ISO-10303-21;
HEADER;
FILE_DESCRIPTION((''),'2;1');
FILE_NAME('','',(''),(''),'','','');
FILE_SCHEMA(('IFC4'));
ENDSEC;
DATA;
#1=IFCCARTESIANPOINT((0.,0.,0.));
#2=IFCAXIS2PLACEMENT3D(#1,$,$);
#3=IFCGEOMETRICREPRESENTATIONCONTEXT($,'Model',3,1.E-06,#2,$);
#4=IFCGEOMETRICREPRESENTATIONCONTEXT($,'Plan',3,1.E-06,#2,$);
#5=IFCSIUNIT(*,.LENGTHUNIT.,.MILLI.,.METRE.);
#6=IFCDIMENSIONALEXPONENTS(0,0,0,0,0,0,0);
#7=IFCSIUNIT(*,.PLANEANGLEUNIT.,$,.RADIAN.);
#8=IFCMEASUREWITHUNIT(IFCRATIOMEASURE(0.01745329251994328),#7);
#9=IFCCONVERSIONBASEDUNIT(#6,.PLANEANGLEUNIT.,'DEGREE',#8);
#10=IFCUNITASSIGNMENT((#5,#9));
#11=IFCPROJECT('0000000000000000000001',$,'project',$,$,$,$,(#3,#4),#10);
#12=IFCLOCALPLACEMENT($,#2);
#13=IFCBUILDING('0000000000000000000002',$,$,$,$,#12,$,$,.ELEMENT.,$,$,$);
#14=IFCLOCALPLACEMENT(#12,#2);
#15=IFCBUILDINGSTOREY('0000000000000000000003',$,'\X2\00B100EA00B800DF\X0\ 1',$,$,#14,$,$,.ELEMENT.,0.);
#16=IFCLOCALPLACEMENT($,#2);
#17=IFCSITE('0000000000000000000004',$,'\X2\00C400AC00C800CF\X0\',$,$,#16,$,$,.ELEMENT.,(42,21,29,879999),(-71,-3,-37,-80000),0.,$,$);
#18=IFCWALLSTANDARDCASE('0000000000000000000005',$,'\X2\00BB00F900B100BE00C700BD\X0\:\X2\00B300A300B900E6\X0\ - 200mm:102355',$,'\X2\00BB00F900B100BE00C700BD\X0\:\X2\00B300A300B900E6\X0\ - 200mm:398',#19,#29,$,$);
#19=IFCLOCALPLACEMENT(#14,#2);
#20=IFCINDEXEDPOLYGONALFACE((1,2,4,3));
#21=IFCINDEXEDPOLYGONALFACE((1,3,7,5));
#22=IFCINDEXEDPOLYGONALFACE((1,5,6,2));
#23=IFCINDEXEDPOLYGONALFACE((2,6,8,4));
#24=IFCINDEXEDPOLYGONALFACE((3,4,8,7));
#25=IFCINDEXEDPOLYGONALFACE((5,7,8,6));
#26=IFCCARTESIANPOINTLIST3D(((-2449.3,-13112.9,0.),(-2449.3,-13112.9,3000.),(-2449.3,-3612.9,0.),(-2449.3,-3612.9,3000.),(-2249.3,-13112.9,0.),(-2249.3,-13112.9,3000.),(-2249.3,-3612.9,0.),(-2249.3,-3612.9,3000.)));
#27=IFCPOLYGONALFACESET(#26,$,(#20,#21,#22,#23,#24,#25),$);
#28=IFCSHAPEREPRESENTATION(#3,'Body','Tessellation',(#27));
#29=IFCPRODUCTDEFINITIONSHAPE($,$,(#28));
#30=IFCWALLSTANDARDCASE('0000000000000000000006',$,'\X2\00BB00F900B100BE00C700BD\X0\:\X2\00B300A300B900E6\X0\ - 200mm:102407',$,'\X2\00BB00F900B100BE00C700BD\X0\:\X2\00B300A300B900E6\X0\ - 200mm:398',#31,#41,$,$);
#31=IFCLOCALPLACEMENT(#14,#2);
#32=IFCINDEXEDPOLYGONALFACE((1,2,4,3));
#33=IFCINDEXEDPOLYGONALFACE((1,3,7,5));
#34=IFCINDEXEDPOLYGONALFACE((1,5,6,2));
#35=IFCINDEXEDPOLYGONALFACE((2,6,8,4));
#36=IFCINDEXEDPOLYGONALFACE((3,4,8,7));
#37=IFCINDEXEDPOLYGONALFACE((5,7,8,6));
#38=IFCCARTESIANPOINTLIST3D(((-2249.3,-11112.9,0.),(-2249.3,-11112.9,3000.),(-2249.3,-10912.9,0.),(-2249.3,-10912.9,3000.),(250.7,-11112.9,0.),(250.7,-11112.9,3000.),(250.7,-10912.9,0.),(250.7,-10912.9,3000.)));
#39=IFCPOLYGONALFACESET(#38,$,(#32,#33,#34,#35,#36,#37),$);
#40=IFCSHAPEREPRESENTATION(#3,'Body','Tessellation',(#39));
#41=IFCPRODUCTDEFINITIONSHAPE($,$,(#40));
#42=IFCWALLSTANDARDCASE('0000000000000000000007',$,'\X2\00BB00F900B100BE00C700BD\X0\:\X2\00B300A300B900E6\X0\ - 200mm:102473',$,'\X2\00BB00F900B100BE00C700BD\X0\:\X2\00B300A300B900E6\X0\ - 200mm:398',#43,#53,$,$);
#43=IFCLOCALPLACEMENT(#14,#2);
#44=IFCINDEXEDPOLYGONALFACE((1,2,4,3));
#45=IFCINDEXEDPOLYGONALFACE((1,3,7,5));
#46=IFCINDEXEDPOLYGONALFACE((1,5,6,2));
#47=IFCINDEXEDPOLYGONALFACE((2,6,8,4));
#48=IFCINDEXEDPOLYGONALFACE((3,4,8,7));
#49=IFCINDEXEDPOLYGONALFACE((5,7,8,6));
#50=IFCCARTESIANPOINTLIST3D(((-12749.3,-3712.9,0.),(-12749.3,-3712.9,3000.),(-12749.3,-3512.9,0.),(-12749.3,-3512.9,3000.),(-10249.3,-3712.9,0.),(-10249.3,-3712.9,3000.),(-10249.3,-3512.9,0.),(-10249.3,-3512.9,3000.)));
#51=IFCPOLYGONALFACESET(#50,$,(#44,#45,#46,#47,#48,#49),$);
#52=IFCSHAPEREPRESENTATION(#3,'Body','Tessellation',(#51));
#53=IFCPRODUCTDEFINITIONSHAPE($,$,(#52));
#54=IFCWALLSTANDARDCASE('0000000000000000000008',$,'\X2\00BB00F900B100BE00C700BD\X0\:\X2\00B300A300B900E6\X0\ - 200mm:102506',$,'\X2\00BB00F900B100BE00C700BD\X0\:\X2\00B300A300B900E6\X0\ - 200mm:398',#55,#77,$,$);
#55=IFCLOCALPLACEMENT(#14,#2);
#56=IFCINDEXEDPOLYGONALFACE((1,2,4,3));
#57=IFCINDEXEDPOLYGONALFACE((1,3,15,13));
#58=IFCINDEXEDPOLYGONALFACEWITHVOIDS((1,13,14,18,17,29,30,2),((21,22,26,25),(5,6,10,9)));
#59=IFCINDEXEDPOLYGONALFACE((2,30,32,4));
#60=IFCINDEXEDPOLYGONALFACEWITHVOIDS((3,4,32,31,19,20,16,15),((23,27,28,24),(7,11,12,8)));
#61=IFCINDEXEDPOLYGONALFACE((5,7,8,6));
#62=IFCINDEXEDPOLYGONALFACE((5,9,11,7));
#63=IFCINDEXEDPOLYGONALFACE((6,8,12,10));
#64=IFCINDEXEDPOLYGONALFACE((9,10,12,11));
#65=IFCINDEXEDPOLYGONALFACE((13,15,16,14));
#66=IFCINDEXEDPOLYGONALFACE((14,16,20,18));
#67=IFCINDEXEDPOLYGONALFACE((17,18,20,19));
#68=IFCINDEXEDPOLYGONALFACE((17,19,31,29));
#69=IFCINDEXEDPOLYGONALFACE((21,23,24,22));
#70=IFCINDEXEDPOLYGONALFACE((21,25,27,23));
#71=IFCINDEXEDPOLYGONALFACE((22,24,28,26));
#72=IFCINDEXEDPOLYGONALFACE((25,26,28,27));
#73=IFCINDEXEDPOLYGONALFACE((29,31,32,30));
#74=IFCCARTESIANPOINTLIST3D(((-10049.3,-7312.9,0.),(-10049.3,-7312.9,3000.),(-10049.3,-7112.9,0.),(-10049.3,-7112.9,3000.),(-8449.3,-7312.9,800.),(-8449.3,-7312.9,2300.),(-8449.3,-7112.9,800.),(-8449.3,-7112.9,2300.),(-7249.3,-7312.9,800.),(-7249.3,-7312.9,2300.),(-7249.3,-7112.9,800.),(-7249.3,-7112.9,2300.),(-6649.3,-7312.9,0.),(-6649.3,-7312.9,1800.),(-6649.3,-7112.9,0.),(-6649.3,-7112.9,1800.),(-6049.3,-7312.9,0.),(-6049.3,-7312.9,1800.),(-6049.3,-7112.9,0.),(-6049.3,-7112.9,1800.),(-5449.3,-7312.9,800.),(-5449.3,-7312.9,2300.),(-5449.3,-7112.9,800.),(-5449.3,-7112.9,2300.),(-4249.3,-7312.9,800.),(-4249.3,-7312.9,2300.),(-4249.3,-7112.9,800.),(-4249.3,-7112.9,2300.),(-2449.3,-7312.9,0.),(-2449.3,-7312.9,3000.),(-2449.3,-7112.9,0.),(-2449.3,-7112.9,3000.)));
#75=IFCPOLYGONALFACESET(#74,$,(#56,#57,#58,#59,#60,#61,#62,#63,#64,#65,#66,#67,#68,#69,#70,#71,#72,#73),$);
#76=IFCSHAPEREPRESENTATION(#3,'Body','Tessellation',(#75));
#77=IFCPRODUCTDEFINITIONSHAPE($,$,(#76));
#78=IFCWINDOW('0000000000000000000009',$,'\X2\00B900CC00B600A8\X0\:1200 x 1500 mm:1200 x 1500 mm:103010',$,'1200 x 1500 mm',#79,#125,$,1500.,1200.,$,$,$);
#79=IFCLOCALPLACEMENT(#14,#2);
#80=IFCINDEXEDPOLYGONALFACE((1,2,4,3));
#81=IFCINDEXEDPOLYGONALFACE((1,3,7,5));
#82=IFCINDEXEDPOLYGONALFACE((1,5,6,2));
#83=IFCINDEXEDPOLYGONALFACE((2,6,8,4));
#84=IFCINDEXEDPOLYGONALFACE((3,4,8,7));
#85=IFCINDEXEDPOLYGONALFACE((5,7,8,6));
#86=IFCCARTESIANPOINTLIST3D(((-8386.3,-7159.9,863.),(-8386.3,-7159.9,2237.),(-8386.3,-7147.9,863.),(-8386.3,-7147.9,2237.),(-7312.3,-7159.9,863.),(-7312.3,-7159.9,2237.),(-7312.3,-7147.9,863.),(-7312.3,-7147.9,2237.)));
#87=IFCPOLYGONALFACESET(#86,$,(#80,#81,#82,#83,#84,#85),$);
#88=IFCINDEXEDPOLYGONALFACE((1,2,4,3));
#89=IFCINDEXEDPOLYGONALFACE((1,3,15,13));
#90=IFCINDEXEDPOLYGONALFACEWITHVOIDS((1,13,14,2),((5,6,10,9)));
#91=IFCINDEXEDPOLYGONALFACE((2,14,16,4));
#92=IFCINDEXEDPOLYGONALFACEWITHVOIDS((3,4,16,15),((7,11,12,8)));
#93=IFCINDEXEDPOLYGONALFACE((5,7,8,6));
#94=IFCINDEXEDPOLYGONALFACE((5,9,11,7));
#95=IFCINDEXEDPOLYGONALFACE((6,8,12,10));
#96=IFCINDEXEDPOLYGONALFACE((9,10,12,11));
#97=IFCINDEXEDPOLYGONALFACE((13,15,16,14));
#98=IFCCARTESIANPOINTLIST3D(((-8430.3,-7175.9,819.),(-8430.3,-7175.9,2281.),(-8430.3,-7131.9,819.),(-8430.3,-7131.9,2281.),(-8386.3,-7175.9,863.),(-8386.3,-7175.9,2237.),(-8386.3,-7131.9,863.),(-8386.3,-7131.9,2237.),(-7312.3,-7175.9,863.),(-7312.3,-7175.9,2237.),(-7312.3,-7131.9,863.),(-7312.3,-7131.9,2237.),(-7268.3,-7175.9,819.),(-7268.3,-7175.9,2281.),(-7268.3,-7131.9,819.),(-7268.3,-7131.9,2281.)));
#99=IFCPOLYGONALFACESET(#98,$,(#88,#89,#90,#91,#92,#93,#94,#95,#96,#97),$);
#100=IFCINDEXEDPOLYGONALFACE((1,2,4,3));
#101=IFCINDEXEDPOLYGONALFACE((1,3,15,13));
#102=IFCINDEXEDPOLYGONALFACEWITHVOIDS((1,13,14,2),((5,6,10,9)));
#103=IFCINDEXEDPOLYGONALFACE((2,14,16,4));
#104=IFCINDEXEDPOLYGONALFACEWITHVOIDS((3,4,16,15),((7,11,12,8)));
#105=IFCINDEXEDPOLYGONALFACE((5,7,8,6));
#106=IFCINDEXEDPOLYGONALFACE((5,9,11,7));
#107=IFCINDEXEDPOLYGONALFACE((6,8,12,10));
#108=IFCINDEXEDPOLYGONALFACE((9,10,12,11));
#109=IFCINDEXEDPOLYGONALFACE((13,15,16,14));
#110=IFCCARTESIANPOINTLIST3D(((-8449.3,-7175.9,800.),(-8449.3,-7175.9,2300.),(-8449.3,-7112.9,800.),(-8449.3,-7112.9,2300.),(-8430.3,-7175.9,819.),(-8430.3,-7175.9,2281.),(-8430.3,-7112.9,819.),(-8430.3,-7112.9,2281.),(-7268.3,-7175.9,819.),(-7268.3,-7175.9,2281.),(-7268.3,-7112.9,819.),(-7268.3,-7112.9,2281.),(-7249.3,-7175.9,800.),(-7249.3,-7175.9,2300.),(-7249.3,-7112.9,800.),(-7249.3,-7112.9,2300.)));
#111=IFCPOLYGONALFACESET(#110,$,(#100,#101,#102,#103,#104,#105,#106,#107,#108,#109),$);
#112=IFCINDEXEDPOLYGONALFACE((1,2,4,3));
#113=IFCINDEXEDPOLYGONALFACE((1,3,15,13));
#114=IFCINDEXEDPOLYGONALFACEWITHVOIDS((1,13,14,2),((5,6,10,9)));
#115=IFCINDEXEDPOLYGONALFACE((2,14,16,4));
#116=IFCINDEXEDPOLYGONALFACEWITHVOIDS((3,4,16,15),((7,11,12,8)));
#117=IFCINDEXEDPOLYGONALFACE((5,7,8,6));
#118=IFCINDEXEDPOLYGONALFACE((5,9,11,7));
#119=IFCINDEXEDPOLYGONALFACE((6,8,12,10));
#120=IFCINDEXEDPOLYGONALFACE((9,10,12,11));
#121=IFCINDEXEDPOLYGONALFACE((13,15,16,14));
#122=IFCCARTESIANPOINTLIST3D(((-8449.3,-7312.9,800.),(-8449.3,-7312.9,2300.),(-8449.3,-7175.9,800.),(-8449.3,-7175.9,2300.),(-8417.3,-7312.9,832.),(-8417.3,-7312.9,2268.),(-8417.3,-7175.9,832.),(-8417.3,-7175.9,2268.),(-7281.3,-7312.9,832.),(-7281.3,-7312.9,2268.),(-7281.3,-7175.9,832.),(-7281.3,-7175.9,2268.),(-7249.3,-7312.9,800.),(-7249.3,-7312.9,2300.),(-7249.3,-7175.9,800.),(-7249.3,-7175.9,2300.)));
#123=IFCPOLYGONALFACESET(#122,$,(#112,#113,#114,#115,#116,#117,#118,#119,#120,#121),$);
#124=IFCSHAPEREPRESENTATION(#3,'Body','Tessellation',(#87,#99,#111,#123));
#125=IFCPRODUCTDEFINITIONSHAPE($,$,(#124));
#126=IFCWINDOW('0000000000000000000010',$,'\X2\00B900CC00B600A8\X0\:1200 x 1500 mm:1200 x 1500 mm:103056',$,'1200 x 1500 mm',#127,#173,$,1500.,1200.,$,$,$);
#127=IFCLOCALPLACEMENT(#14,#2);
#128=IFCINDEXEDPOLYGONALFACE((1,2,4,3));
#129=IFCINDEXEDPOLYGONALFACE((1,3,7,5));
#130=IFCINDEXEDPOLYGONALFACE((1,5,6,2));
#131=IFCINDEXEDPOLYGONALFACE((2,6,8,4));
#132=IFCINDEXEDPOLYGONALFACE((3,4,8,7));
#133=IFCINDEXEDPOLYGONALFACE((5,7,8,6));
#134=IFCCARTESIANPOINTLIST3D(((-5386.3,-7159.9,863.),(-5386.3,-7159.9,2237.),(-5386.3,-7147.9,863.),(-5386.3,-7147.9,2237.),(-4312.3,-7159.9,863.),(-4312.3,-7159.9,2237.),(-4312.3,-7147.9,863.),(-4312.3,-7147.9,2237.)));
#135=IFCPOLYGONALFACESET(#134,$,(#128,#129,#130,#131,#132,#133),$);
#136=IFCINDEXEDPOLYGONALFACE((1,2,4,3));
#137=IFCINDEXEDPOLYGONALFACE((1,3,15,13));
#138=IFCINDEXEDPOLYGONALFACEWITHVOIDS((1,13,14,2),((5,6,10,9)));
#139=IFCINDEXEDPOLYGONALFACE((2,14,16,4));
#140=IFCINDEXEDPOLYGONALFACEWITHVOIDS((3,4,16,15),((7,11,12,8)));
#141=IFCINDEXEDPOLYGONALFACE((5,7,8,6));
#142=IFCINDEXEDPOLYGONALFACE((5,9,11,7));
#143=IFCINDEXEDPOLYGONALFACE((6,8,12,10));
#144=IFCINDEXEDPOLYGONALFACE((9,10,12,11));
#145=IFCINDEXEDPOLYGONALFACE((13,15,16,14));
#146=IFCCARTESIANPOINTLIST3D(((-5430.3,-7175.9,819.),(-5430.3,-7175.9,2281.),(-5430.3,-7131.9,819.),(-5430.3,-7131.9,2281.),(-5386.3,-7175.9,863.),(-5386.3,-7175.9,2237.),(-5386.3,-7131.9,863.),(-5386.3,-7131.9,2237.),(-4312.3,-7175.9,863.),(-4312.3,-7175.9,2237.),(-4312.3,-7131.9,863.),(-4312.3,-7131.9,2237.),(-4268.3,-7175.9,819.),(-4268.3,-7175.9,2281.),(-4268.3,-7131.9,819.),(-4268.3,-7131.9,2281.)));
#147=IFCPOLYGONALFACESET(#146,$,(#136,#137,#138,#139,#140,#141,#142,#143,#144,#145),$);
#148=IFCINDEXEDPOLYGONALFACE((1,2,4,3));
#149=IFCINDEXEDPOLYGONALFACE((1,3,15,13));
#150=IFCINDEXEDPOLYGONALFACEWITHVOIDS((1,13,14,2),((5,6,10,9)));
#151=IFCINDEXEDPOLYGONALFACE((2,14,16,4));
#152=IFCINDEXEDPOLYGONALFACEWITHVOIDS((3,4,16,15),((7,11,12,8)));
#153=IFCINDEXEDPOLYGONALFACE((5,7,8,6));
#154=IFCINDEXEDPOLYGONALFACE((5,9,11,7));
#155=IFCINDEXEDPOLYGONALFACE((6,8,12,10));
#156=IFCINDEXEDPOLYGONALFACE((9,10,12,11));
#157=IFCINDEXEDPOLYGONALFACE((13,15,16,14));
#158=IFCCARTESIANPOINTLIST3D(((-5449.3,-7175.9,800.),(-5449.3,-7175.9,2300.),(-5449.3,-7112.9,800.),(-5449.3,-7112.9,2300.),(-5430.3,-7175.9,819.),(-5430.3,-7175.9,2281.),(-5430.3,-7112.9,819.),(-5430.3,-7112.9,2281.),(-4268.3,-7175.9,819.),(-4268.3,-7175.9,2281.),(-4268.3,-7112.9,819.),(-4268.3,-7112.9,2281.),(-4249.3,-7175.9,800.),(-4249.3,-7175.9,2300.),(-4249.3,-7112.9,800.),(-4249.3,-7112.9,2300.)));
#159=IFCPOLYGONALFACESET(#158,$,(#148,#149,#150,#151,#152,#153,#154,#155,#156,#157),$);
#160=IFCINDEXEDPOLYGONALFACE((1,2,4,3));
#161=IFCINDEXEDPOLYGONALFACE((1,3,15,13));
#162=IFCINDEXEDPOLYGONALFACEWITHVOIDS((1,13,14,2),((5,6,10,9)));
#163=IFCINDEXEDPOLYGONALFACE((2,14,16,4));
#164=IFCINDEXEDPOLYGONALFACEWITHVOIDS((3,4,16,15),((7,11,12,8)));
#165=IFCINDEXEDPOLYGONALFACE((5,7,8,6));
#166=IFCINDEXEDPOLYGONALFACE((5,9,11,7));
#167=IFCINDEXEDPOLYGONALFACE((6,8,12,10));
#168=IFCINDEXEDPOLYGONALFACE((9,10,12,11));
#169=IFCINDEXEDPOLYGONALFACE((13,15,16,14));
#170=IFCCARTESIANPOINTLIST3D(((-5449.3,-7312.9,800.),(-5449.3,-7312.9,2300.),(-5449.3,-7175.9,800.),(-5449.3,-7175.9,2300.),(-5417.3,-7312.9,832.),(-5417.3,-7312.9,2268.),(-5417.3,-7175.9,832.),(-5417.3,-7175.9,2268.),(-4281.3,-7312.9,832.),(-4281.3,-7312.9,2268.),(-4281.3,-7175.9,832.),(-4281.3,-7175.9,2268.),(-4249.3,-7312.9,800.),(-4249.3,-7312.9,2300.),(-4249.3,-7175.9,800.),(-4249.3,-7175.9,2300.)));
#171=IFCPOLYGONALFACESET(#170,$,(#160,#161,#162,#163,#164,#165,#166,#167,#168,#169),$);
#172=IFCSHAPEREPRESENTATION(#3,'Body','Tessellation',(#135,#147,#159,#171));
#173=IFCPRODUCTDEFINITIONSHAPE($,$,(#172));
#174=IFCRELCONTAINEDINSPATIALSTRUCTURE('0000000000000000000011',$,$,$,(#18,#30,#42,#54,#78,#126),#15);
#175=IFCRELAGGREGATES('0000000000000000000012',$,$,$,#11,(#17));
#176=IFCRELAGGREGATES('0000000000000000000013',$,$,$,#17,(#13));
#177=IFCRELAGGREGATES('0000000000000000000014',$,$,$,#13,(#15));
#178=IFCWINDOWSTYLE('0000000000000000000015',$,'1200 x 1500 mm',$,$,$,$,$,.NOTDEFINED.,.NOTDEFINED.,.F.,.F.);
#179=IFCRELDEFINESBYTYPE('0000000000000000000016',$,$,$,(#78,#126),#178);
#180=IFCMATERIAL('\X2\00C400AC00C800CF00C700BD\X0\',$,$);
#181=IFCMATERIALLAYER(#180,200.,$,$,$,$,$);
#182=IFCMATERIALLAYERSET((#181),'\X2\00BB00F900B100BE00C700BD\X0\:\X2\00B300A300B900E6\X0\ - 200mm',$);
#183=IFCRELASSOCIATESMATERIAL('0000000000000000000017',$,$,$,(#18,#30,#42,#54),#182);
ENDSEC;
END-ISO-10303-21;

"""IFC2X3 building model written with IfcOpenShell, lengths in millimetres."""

from ifc_helpers import new_model, entity, si_unit, converted_unit, frame, frame_2d, origin, origin_2d_with_axis, place, context, project, spatial, polyline, rectangle, outline, extrude, source, transform, mapped, material, layer, layer_set, layer_usage, type_object, type_shapes, element, fill, save


model = new_model("IFC2X3")

# Units and contexts
model_context = context("Model", 3, precision=1e-06, world=origin())
plan_context = context("Plan", 3, precision=1e-06, world=origin())
ifc_project = project(units=[si_unit("LENGTHUNIT", "METRE", prefix="MILLI"), converted_unit("PLANEANGLEUNIT", "DEGREE", entity("IfcRatioMeasure", 0.01745329251994328), si_unit("PLANEANGLEUNIT", "RADIAN"), dimensions=[0, 0, 0, 0, 0, 0, 0])], contexts=[model_context, plan_context])

# Site, building, storey
site_placement = place(None, origin())
site = spatial("IfcSite", under=ifc_project, at=site_placement, Name="Ä¬ÈÏ", CompositionType="ELEMENT", RefLatitude=(42, 21, 29, 879999), RefLongitude=(-71, -3, -37, -80000), RefElevation=0.0)
building_placement = place(None, origin())
building = spatial("IfcBuilding", under=site, at=building_placement, CompositionType="ELEMENT")
storey_placement = place(building_placement, origin())
storey = spatial("IfcBuildingStorey", under=building, at=storey_placement, Name="±ê¸ß 1", CompositionType="ELEMENT", Elevation=0.0)

# Shared definitions
ifc_material_1 = material(Name="Ä¬ÈÏÇ½")
ifc_layer_1 = layer(ifc_material_1, 200.0)
ifc_layer_set_1 = layer_set([ifc_layer_1], Name="»ù±¾Ç½:³£¹æ - 200mm")
window_style = type_object("IfcWindowStyle", Name="1200 x 1500 mm", ConstructionType="NOTDEFINED", OperationType="NOTDEFINED", ParameterTakesPrecedence=False, Sizeable=False)
shared_shape = source(origin(), model_context, "Body", "SweptSolid", [
    extrude(rectangle(XDim=12.0, YDim=1074.0, at=origin_2d_with_axis()), frame((600.0, 159.0, 63.0), z_axis=(0.0, 0.0, 1.0), x_axis=(0.0, -1.0, 0.0)), (0.0, 0.0, 1.0), 1374.0),
    extrude(outline(polyline([(-581.0, -731.0), (581.0, -731.0), (581.0, 731.0), (-581.0, 731.0), (-581.0, -731.0)]), holes=[polyline([(-537.0, -687.0), (-537.0, 687.0), (537.0, 687.0), (537.0, -687.0), (-537.0, -687.0)])]), frame((600.0, 137.0, 750.0), z_axis=(0.0, 1.0, 0.0), x_axis=(1.0, 0.0, 0.0)), (0.0, 0.0, 1.0), 44.0),
    extrude(outline(polyline([(-600.0, -750.0), (600.0, -750.0), (600.0, 750.0), (-600.0, 750.0), (-600.0, -750.0)]), holes=[polyline([(-581.0, -731.0), (-581.0, 731.0), (581.0, 731.0), (581.0, -731.0), (-581.0, -731.0)])]), frame((600.0, 137.0, 750.0), z_axis=(0.0, 1.0, 0.0), x_axis=(1.0, 0.0, 0.0)), (0.0, 0.0, 1.0), 63.0),
    extrude(outline(polyline([(-600.0, -750.0), (600.0, -750.0), (600.0, 750.0), (-600.0, 750.0), (-600.0, -750.0)]), holes=[polyline([(-568.0, -718.0), (-568.0, 718.0), (568.0, 718.0), (568.0, -718.0), (-568.0, -718.0)])]), frame((600.0, 0.0, 750.0), z_axis=(0.0, 1.0, 0.0), x_axis=(1.0, 0.0, 0.0)), (0.0, 0.0, 1.0), 137.0),
])
type_shapes(window_style, [shared_shape])

# Walls
ifc_layer_usage_1 = layer_usage(ifc_layer_set_1, "AXIS2", "NEGATIVE", 100.0)
wall_1_placement = place(storey_placement, frame((-2349.3, -3612.9, 0.0), z_axis=(0.0, 0.0, 1.0), x_axis=(0.0, -1.0, 0.0)))
element("IfcWallStandardCase", 1, at=wall_1_placement, inside=storey, material=ifc_layer_usage_1, Name="»ù±¾Ç½:³£¹æ - 200mm:102355", ObjectType="»ù±¾Ç½:³£¹æ - 200mm:398", context=model_context, shape_type="SweptSolid", body=[
    extrude(rectangle(XDim=9500.0, YDim=200.0, at=frame_2d((4750.0, 0.0), x_axis=(-1.0, 0.0))), origin(), (0.0, 0.0, 1.0), 3000.0),
])
ifc_layer_usage_2 = layer_usage(ifc_layer_set_1, "AXIS2", "NEGATIVE", 100.0)
wall_2_placement = place(storey_placement, frame((-2249.3, -11012.9, 0.0)))
element("IfcWallStandardCase", 2, at=wall_2_placement, inside=storey, material=ifc_layer_usage_2, Name="»ù±¾Ç½:³£¹æ - 200mm:102407", ObjectType="»ù±¾Ç½:³£¹æ - 200mm:398", context=model_context, shape_type="SweptSolid", body=[
    extrude(rectangle(XDim=2500.0, YDim=200.0, at=frame_2d((1250.0, 0.0), x_axis=(-1.0, 0.0))), origin(), (0.0, 0.0, 1.0), 3000.0),
])
ifc_layer_usage_3 = layer_usage(ifc_layer_set_1, "AXIS2", "NEGATIVE", 100.0)
wall_3_placement = place(storey_placement, frame((-12749.3, -3612.9, 0.0)))
element("IfcWallStandardCase", 3, at=wall_3_placement, inside=storey, material=ifc_layer_usage_3, Name="»ù±¾Ç½:³£¹æ - 200mm:102473", ObjectType="»ù±¾Ç½:³£¹æ - 200mm:398", context=model_context, shape_type="SweptSolid", body=[
    extrude(rectangle(XDim=2500.0, YDim=200.0, at=frame_2d((1250.0, 0.0), x_axis=(-1.0, 0.0))), origin(), (0.0, 0.0, 1.0), 3000.0),
])

# Wall, openings, windows
ifc_layer_usage_4 = layer_usage(ifc_layer_set_1, "AXIS2", "NEGATIVE", 100.0)
wall_4_placement = place(storey_placement, frame((-10049.3, -7212.9, 0.0)))
wall_4 = element("IfcWallStandardCase", 4, at=wall_4_placement, inside=storey, material=ifc_layer_usage_4, Name="»ù±¾Ç½:³£¹æ - 200mm:102506", ObjectType="»ù±¾Ç½:³£¹æ - 200mm:398", context=model_context, shape_type="SweptSolid", body=[
    extrude(rectangle(XDim=7600.0, YDim=200.0, at=frame_2d((3800.0, 0.0), x_axis=(-1.0, 0.0))), origin(), (0.0, 0.0, 1.0), 3000.0),
])
opening_1_placement = place(wall_4_placement, frame((1600.0, -100.0, 800.0)))
opening_1 = element("IfcOpeningElement", 5, at=opening_1_placement, cuts=wall_4, ObjectType="Opening", context=model_context, shape_type="SweptSolid", body=[
    extrude(rectangle(XDim=1500.0, YDim=1200.0, at=frame_2d((750.0, 600.0), x_axis=(1.0, 0.0))), frame((0.0, 0.0, 0.0), z_axis=(0.0, 1.0, 0.0), x_axis=(0.0, 0.0, 1.0)), (0.0, 0.0, 1.0), 200.0),
])
opening_2_placement = place(wall_4_placement, frame((4600.0, -100.0, 800.0)))
opening_2 = element("IfcOpeningElement", 6, at=opening_2_placement, cuts=wall_4, ObjectType="Opening", context=model_context, shape_type="SweptSolid", body=[
    extrude(rectangle(XDim=1500.0, YDim=1200.0, at=frame_2d((750.0, 600.0), x_axis=(1.0, 0.0))), frame((0.0, 0.0, 0.0), z_axis=(0.0, 1.0, 0.0), x_axis=(0.0, 0.0, 1.0)), (0.0, 0.0, 1.0), 200.0),
])
opening_3_placement = place(wall_4_placement, frame((4000.0, 100.0, 0.0)))
element("IfcOpeningElement", 7, at=opening_3_placement, cuts=wall_4, ObjectType="Opening", context=model_context, shape_type="SweptSolid", body=[
    extrude(rectangle(XDim=1800.0, YDim=600.0, at=frame_2d((900.0, 300.0), x_axis=(1.0, 0.0))), frame((0.0, 0.0, 0.0), z_axis=(0.0, -1.0, 0.0), x_axis=(0.0, 0.0, 1.0)), (0.0, 0.0, 1.0), 200.0),
])
window_1_placement = place(opening_1_placement, origin())
window_1 = element("IfcWindow", 8, at=window_1_placement, inside=storey, type_object=window_style, Name="¹Ì¶¨:1200 x 1500 mm:1200 x 1500 mm:103010", ObjectType="1200 x 1500 mm", OverallHeight=1500.0, OverallWidth=1200.0, context=model_context, shape_type="MappedRepresentation", body=[
    mapped(shared_shape, transform((0.0, 0.0, 0.0), scale=1.0)),
])
fill(opening_1, window_1)
window_2_placement = place(opening_2_placement, origin())
window_2 = element("IfcWindow", 9, at=window_2_placement, inside=storey, type_object=window_style, Name="¹Ì¶¨:1200 x 1500 mm:1200 x 1500 mm:103056", ObjectType="1200 x 1500 mm", OverallHeight=1500.0, OverallWidth=1200.0, context=model_context, shape_type="MappedRepresentation", body=[
    mapped(shared_shape, transform((0.0, 0.0, 0.0), scale=1.0)),
])
fill(opening_2, window_2)

save(model, "model.ifc")
